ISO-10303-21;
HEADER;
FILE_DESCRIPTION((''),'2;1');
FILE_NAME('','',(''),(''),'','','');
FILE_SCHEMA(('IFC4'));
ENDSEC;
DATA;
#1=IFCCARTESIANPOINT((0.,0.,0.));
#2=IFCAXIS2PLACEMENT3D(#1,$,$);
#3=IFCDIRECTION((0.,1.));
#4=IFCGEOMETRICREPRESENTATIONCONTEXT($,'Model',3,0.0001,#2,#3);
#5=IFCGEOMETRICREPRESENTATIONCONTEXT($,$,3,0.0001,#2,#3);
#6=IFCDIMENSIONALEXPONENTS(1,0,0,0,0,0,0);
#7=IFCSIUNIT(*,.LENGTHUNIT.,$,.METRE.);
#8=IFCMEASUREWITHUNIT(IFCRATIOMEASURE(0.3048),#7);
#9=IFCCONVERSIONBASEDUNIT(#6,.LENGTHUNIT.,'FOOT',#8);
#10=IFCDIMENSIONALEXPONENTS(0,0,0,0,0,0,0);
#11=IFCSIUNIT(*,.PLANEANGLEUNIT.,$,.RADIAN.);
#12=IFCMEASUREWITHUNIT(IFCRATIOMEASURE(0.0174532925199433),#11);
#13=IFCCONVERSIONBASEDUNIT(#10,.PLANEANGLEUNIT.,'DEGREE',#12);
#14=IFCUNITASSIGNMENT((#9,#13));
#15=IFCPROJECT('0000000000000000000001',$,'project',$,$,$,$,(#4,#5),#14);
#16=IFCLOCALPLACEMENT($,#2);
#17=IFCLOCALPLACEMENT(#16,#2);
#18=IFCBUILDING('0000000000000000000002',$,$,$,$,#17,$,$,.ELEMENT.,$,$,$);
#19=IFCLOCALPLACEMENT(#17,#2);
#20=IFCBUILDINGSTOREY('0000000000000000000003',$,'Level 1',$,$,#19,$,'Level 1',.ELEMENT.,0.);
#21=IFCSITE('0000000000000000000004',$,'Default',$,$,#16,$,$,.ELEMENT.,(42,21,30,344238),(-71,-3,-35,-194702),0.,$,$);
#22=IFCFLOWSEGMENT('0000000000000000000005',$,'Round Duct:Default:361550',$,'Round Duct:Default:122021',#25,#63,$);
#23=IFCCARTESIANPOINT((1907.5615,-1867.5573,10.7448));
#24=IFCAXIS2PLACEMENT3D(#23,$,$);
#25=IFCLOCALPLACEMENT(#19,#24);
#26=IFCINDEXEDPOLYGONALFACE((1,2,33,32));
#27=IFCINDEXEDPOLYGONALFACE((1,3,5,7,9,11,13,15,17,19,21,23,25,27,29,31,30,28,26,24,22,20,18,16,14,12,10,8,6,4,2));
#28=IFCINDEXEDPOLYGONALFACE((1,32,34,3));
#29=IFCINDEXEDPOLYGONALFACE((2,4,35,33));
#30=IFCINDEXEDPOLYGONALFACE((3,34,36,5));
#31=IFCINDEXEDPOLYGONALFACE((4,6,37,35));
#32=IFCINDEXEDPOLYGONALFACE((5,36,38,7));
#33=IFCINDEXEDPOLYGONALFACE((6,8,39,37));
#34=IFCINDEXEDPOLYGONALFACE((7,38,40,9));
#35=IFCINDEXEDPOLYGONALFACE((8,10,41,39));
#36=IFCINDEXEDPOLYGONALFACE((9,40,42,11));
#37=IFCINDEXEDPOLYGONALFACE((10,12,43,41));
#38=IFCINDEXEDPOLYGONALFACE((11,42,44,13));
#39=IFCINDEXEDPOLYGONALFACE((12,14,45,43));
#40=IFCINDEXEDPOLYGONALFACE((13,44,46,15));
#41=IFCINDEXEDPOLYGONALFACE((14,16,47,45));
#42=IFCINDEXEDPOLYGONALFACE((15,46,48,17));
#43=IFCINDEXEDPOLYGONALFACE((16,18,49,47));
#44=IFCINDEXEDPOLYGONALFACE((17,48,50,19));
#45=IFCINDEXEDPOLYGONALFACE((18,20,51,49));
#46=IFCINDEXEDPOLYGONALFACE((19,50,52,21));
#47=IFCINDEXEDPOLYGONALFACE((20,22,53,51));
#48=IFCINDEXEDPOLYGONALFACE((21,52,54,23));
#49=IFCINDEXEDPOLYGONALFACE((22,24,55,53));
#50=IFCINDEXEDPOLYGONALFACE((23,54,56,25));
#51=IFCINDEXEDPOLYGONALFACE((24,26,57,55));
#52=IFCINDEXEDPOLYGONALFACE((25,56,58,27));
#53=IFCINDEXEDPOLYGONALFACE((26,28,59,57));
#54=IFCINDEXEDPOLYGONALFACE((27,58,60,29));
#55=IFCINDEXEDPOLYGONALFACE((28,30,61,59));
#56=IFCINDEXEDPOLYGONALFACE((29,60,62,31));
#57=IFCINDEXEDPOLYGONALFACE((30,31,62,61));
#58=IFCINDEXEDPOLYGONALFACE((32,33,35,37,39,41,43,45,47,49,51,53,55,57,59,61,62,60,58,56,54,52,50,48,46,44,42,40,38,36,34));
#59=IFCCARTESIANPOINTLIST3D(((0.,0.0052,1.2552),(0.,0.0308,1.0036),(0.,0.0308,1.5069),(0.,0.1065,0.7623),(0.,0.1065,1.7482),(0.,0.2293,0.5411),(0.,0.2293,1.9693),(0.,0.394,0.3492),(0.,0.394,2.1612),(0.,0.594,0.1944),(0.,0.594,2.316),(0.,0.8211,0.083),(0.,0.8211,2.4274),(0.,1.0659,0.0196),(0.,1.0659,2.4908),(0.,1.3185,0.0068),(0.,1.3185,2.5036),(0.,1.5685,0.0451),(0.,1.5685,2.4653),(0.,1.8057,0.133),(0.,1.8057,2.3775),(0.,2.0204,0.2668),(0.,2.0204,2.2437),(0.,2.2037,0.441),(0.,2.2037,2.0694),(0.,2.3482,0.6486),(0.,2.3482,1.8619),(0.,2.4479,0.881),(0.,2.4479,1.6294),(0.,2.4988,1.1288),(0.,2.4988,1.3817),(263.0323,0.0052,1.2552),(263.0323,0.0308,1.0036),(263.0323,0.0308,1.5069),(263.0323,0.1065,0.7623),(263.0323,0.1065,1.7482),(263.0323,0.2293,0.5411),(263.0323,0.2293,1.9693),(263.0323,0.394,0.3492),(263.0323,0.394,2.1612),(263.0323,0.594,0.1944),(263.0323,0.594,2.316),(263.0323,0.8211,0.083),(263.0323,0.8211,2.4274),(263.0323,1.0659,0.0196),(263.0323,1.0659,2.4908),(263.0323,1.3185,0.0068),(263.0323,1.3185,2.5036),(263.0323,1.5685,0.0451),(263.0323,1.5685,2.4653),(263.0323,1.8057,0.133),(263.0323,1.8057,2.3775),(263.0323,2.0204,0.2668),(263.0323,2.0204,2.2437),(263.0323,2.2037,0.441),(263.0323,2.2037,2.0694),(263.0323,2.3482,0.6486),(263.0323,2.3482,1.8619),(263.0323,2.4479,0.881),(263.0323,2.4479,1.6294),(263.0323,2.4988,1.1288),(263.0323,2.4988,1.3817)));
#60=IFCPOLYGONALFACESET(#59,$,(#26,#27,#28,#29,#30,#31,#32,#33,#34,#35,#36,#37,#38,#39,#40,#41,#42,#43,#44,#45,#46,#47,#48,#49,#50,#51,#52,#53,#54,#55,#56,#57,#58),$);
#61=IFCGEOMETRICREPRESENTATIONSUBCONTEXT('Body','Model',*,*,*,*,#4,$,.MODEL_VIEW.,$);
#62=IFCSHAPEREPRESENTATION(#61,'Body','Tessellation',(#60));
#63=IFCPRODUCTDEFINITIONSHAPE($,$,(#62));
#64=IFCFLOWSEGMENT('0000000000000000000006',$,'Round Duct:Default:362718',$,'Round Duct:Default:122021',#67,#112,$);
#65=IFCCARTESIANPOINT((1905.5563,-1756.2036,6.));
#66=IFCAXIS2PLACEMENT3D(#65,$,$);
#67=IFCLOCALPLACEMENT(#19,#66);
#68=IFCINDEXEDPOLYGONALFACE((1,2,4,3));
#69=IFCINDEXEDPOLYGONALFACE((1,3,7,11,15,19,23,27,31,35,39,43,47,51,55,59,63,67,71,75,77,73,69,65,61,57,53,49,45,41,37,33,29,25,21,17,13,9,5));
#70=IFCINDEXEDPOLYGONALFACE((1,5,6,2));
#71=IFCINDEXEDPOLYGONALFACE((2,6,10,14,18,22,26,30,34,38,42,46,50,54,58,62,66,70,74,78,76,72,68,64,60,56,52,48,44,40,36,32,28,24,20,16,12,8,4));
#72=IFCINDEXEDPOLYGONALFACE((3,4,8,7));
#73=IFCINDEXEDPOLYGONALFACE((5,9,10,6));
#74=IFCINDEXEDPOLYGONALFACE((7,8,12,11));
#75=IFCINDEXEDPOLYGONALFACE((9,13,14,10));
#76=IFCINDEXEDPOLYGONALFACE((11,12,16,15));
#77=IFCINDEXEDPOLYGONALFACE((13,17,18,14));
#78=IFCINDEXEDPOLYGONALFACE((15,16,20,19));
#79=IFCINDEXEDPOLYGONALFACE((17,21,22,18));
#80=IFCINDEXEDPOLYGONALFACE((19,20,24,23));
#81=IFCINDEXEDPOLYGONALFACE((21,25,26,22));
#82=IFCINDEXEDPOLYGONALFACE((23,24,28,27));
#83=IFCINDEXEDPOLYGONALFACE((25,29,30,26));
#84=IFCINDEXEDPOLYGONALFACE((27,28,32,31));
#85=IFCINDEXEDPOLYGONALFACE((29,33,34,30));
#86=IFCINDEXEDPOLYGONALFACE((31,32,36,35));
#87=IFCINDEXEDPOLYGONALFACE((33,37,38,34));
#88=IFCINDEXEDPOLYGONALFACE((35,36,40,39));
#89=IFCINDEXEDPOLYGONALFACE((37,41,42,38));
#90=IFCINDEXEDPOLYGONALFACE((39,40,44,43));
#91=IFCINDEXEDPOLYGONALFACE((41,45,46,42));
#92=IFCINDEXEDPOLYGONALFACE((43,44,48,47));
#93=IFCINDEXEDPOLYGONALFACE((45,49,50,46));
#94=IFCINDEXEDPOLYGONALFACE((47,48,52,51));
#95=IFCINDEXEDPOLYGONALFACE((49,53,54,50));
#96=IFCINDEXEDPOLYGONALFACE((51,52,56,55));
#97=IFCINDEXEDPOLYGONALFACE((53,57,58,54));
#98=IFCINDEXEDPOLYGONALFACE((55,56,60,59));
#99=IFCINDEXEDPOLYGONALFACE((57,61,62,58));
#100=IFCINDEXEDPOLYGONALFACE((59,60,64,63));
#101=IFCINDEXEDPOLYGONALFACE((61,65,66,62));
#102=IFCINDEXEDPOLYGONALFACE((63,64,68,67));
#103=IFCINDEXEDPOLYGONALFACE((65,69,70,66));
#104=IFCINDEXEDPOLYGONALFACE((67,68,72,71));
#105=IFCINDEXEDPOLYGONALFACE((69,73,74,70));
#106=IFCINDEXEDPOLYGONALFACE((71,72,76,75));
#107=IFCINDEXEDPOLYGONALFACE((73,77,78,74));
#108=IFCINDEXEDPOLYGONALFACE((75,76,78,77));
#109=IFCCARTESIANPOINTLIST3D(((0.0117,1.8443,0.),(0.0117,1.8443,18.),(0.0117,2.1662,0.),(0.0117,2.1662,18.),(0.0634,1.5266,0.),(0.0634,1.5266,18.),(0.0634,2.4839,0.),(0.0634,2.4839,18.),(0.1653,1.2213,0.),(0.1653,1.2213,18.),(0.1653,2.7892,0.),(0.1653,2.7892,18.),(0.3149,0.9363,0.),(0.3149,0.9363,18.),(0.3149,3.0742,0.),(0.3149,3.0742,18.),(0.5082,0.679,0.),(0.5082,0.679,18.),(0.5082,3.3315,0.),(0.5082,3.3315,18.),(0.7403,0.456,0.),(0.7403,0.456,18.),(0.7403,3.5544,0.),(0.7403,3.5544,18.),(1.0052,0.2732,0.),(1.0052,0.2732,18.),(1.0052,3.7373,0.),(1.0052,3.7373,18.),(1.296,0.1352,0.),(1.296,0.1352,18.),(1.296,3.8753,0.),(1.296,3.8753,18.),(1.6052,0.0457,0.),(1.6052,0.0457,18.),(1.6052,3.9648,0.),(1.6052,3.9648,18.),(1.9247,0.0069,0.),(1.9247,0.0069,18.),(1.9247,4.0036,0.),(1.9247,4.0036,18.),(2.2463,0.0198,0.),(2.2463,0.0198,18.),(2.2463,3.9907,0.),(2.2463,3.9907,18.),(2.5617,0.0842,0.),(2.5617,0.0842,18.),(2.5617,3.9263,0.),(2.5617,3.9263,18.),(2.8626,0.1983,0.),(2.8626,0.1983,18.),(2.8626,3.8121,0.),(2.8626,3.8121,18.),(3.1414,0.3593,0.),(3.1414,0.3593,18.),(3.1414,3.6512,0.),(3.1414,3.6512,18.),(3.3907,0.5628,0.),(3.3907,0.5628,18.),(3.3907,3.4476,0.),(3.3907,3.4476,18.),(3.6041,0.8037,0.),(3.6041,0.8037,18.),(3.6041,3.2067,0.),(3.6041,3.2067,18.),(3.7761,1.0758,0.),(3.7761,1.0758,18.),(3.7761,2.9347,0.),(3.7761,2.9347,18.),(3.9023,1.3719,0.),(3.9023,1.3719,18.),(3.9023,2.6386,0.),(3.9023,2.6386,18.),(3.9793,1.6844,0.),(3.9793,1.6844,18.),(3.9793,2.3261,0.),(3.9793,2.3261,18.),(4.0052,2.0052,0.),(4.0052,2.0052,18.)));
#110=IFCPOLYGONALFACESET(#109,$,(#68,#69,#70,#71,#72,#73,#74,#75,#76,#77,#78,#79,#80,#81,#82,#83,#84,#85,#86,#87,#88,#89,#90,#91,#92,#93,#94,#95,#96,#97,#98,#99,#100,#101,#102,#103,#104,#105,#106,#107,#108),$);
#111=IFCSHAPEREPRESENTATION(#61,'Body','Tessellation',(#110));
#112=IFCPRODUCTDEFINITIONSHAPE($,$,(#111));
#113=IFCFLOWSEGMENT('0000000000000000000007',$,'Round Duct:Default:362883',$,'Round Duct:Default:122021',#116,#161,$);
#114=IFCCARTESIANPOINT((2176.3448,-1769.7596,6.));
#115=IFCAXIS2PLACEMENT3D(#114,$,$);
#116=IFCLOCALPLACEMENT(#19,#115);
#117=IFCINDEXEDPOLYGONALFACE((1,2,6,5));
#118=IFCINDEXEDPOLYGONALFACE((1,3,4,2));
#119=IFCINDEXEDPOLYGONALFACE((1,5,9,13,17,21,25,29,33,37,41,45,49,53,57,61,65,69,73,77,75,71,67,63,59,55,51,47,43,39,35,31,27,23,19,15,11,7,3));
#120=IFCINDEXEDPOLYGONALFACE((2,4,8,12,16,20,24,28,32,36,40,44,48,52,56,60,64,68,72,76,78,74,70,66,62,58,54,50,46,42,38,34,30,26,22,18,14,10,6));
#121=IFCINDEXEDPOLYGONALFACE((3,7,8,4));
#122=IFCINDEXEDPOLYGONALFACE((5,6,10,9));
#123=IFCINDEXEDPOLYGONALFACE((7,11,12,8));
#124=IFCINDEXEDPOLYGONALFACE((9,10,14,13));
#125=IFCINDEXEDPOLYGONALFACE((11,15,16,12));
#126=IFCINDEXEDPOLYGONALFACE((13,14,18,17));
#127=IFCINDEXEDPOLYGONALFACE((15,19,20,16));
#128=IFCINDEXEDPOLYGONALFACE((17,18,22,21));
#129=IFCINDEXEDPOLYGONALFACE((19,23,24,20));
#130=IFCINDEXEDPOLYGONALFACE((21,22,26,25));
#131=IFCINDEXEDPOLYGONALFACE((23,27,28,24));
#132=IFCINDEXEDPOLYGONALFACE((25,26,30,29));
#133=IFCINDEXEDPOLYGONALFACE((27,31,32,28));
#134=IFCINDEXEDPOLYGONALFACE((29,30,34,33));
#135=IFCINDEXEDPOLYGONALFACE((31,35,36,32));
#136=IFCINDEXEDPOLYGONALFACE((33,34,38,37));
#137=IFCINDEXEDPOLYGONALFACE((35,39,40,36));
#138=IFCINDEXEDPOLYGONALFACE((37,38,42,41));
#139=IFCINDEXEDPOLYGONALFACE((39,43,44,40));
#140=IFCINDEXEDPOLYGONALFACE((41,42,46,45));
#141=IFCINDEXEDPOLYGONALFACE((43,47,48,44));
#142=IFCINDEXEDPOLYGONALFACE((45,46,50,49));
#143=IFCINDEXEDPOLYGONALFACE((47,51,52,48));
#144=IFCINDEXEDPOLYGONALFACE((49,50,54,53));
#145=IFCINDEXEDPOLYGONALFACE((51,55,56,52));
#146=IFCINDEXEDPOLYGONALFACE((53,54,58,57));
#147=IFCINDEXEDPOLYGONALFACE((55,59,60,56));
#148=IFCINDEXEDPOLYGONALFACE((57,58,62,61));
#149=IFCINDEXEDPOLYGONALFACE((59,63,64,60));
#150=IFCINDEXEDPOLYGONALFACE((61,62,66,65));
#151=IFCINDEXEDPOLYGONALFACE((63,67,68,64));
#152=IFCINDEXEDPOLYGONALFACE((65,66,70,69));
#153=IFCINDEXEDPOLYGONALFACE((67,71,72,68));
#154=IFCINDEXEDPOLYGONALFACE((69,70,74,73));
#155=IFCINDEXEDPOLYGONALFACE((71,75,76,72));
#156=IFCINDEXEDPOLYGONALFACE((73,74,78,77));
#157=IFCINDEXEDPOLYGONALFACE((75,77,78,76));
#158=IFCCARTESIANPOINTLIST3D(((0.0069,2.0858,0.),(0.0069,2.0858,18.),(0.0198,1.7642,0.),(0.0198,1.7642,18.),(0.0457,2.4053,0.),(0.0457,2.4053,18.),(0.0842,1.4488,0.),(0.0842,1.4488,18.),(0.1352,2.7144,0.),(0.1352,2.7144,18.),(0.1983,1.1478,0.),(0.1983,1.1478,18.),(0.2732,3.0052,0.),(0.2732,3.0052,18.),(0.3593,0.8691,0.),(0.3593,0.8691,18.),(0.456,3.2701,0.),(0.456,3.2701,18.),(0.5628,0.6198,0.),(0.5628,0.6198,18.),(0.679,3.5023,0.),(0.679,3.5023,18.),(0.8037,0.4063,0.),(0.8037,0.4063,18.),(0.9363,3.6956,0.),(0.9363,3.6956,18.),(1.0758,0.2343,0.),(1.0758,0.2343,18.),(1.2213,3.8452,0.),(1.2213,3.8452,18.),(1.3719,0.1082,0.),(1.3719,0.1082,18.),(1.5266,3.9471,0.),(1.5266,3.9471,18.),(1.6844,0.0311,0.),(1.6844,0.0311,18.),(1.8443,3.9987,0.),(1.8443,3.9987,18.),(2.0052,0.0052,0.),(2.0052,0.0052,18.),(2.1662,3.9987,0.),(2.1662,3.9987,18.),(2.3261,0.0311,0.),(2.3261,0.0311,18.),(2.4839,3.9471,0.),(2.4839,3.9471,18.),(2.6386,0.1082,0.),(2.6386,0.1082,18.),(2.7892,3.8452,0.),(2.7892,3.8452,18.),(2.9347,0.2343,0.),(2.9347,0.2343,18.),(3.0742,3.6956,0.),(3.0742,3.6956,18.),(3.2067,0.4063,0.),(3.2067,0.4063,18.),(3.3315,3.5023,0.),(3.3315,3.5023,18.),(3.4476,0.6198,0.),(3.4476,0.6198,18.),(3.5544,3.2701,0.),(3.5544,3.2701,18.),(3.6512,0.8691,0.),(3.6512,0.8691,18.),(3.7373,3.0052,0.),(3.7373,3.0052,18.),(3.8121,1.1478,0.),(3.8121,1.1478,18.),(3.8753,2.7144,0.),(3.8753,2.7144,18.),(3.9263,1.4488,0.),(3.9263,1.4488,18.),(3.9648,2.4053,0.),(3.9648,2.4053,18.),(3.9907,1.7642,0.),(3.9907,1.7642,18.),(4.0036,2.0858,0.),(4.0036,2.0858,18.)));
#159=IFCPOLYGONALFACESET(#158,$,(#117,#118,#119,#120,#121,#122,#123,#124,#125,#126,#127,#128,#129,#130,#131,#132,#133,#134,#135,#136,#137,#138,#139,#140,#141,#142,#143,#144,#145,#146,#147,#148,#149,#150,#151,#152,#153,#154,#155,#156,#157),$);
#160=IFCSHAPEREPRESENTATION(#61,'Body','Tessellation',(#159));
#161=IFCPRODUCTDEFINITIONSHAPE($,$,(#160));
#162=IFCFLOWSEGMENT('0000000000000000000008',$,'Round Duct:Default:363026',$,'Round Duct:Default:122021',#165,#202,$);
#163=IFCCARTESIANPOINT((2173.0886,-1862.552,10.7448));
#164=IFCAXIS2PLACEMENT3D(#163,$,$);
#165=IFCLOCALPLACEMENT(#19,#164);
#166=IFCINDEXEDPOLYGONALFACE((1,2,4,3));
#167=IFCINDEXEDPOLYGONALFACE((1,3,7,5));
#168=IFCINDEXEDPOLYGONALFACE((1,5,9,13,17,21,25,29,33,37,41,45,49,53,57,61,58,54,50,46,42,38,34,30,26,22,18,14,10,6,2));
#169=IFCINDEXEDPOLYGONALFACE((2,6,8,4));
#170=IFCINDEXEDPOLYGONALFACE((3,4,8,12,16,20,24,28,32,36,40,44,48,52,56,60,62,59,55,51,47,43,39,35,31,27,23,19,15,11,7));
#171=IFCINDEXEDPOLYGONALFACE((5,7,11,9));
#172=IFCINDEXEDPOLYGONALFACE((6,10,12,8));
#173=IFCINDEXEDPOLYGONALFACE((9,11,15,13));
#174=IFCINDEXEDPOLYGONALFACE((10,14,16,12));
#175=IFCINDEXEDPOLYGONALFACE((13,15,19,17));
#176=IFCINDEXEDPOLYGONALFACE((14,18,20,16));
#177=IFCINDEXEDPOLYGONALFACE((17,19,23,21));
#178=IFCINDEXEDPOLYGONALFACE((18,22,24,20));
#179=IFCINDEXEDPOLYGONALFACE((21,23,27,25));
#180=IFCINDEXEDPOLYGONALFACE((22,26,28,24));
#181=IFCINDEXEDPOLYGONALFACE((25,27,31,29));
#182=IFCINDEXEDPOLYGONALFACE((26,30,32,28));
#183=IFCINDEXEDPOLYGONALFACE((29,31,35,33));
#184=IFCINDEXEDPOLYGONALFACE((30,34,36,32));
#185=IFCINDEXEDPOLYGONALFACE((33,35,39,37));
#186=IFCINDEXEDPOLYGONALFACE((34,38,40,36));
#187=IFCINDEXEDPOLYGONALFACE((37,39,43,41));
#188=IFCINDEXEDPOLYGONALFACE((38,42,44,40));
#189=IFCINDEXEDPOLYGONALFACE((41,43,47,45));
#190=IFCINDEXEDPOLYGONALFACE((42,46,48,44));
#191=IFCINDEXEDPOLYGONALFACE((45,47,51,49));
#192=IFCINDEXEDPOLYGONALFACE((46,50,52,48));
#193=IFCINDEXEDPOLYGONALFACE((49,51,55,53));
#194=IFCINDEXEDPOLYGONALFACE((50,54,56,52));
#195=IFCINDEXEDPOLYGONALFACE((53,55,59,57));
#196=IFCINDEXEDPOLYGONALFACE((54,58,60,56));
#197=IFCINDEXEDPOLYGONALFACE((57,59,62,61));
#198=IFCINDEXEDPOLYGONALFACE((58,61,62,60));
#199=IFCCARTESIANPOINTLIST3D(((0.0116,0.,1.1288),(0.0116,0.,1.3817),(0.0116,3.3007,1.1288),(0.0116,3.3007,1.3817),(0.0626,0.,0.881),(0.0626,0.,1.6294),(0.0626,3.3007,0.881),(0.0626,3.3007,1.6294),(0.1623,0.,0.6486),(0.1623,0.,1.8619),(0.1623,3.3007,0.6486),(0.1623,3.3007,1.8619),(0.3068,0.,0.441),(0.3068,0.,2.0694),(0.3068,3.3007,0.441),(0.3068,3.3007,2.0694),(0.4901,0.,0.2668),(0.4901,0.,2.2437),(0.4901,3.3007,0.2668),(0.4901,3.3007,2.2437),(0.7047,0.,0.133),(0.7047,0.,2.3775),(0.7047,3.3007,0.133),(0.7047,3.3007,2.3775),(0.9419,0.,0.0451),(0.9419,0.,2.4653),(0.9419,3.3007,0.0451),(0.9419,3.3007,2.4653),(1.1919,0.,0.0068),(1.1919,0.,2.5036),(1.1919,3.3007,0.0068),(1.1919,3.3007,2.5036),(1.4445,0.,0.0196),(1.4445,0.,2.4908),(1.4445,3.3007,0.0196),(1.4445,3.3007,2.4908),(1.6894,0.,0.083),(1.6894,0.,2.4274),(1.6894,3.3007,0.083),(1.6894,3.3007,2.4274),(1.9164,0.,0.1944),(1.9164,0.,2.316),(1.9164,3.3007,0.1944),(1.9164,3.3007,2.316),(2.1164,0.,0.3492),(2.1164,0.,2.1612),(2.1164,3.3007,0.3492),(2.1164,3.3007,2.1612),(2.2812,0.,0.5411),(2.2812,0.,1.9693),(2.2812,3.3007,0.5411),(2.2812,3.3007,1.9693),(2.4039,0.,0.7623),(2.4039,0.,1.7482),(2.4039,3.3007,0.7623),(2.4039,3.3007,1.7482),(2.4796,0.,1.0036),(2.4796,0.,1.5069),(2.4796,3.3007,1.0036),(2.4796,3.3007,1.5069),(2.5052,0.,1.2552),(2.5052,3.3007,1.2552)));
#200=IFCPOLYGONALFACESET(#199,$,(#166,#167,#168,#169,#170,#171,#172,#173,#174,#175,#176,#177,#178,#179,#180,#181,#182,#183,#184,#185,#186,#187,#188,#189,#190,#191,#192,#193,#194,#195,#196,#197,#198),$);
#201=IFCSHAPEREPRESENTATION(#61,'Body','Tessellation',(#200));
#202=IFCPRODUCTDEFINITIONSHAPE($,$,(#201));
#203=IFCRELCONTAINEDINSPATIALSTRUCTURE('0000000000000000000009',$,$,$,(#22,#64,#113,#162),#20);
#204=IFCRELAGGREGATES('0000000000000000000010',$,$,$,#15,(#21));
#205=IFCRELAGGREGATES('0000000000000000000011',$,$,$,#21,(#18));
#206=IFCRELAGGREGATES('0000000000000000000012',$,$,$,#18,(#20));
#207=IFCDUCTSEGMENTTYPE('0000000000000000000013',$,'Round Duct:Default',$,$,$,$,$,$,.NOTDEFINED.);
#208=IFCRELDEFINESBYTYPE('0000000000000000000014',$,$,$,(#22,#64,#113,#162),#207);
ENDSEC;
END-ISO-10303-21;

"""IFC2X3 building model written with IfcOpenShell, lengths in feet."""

from ifc_helpers import new_model, entity, si_unit, converted_unit, direction, frame, frame_2d, origin, place, context, subcontext, project, spatial, circle, extrude, type_object, element, save


model = new_model("IFC2X3")

# Units and contexts
model_context = context("Model", 3, precision=0.0001, world=origin(), true_north=direction((0.0, 1.0)))
context_of_model = context(None, 3, precision=0.0001, world=origin(), true_north=direction((0.0, 1.0)))
body_context = subcontext(model_context, "Body", "Model", "MODEL_VIEW")
ifc_project = project(units=[converted_unit("LENGTHUNIT", "FOOT", entity("IfcRatioMeasure", 0.3048), si_unit("LENGTHUNIT", "METRE"), dimensions=[1, 0, 0, 0, 0, 0, 0]), converted_unit("PLANEANGLEUNIT", "DEGREE", entity("IfcRatioMeasure", 0.0174532925199433), si_unit("PLANEANGLEUNIT", "RADIAN"), dimensions=[0, 0, 0, 0, 0, 0, 0])], contexts=[model_context, context_of_model])

# Site, building, storey
site_placement = place(None, origin())
site = spatial("IfcSite", under=ifc_project, at=site_placement, Name="Default", CompositionType="ELEMENT", RefLatitude=(42, 21, 30, 344238), RefLongitude=(-71, -3, -35, -194702), RefElevation=0.0)
building_placement = place(site_placement, origin())
building = spatial("IfcBuilding", under=site, at=building_placement, CompositionType="ELEMENT")
storey_placement = place(building_placement, origin())
storey = spatial("IfcBuildingStorey", under=building, at=storey_placement, Name="Level 1", LongName="Level 1", CompositionType="ELEMENT", Elevation=0.0)

# Flow segments
duct_segment_type = type_object("IfcDuctSegmentType", Name="Round Duct:Default", PredefinedType="NOTDEFINED")
flow_segment_1_placement = place(storey_placement, frame((1907.5615, -1867.5573, 10.7448)))
element("IfcFlowSegment", 1, at=flow_segment_1_placement, inside=storey, type_object=duct_segment_type, Name="Round Duct:Default:361550", ObjectType="Round Duct:Default:122021", context=body_context, shape_type="SweptSolid", body=[
    extrude(circle(Radius=1.25, at=frame_2d((0.0, 0.0), x_axis=(1.0, 0.0))), frame((0.0, 1.2552, 1.2552), z_axis=(1.0, 0.0, 0.0), x_axis=(0.0, -1.0, 0.0)), (0.0, 0.0, 1.0), 263.0323),
])
flow_segment_2_placement = place(storey_placement, frame((1905.5563, -1756.2036, 6.0)))
element("IfcFlowSegment", 2, at=flow_segment_2_placement, inside=storey, type_object=duct_segment_type, Name="Round Duct:Default:362718", ObjectType="Round Duct:Default:122021", context=body_context, shape_type="SweptSolid", body=[
    extrude(circle(Radius=2.0, at=frame_2d((0.0, 0.0), x_axis=(1.0, 0.0))), frame((2.0052, 2.0052, 0.0)), (0.0, 0.0, 1.0), 18.0),
])
flow_segment_3_placement = place(storey_placement, frame((2176.3448, -1769.7596, 6.0)))
element("IfcFlowSegment", 3, at=flow_segment_3_placement, inside=storey, type_object=duct_segment_type, Name="Round Duct:Default:362883", ObjectType="Round Duct:Default:122021", context=body_context, shape_type="SweptSolid", body=[
    extrude(circle(Radius=2.0, at=frame_2d((0.0, 0.0), x_axis=(1.0, 0.0))), frame((2.0052, 2.0052, 0.0), z_axis=(0.0, 0.0, 1.0), x_axis=(0.0, -1.0, 0.0)), (0.0, 0.0, 1.0), 18.0),
])
flow_segment_4_placement = place(storey_placement, frame((2173.0886, -1862.552, 10.7448)))
element("IfcFlowSegment", 4, at=flow_segment_4_placement, inside=storey, type_object=duct_segment_type, Name="Round Duct:Default:363026", ObjectType="Round Duct:Default:122021", context=body_context, shape_type="SweptSolid", body=[
    extrude(circle(Radius=1.25, at=frame_2d((0.0, 0.0), x_axis=(1.0, 0.0))), frame((1.2552, 0.0, 1.2552), z_axis=(0.0, 1.0, 0.0), x_axis=(1.0, 0.0, 0.0)), (0.0, 0.0, 1.0), 3.3007),
])

save(model, "model.ifc")
